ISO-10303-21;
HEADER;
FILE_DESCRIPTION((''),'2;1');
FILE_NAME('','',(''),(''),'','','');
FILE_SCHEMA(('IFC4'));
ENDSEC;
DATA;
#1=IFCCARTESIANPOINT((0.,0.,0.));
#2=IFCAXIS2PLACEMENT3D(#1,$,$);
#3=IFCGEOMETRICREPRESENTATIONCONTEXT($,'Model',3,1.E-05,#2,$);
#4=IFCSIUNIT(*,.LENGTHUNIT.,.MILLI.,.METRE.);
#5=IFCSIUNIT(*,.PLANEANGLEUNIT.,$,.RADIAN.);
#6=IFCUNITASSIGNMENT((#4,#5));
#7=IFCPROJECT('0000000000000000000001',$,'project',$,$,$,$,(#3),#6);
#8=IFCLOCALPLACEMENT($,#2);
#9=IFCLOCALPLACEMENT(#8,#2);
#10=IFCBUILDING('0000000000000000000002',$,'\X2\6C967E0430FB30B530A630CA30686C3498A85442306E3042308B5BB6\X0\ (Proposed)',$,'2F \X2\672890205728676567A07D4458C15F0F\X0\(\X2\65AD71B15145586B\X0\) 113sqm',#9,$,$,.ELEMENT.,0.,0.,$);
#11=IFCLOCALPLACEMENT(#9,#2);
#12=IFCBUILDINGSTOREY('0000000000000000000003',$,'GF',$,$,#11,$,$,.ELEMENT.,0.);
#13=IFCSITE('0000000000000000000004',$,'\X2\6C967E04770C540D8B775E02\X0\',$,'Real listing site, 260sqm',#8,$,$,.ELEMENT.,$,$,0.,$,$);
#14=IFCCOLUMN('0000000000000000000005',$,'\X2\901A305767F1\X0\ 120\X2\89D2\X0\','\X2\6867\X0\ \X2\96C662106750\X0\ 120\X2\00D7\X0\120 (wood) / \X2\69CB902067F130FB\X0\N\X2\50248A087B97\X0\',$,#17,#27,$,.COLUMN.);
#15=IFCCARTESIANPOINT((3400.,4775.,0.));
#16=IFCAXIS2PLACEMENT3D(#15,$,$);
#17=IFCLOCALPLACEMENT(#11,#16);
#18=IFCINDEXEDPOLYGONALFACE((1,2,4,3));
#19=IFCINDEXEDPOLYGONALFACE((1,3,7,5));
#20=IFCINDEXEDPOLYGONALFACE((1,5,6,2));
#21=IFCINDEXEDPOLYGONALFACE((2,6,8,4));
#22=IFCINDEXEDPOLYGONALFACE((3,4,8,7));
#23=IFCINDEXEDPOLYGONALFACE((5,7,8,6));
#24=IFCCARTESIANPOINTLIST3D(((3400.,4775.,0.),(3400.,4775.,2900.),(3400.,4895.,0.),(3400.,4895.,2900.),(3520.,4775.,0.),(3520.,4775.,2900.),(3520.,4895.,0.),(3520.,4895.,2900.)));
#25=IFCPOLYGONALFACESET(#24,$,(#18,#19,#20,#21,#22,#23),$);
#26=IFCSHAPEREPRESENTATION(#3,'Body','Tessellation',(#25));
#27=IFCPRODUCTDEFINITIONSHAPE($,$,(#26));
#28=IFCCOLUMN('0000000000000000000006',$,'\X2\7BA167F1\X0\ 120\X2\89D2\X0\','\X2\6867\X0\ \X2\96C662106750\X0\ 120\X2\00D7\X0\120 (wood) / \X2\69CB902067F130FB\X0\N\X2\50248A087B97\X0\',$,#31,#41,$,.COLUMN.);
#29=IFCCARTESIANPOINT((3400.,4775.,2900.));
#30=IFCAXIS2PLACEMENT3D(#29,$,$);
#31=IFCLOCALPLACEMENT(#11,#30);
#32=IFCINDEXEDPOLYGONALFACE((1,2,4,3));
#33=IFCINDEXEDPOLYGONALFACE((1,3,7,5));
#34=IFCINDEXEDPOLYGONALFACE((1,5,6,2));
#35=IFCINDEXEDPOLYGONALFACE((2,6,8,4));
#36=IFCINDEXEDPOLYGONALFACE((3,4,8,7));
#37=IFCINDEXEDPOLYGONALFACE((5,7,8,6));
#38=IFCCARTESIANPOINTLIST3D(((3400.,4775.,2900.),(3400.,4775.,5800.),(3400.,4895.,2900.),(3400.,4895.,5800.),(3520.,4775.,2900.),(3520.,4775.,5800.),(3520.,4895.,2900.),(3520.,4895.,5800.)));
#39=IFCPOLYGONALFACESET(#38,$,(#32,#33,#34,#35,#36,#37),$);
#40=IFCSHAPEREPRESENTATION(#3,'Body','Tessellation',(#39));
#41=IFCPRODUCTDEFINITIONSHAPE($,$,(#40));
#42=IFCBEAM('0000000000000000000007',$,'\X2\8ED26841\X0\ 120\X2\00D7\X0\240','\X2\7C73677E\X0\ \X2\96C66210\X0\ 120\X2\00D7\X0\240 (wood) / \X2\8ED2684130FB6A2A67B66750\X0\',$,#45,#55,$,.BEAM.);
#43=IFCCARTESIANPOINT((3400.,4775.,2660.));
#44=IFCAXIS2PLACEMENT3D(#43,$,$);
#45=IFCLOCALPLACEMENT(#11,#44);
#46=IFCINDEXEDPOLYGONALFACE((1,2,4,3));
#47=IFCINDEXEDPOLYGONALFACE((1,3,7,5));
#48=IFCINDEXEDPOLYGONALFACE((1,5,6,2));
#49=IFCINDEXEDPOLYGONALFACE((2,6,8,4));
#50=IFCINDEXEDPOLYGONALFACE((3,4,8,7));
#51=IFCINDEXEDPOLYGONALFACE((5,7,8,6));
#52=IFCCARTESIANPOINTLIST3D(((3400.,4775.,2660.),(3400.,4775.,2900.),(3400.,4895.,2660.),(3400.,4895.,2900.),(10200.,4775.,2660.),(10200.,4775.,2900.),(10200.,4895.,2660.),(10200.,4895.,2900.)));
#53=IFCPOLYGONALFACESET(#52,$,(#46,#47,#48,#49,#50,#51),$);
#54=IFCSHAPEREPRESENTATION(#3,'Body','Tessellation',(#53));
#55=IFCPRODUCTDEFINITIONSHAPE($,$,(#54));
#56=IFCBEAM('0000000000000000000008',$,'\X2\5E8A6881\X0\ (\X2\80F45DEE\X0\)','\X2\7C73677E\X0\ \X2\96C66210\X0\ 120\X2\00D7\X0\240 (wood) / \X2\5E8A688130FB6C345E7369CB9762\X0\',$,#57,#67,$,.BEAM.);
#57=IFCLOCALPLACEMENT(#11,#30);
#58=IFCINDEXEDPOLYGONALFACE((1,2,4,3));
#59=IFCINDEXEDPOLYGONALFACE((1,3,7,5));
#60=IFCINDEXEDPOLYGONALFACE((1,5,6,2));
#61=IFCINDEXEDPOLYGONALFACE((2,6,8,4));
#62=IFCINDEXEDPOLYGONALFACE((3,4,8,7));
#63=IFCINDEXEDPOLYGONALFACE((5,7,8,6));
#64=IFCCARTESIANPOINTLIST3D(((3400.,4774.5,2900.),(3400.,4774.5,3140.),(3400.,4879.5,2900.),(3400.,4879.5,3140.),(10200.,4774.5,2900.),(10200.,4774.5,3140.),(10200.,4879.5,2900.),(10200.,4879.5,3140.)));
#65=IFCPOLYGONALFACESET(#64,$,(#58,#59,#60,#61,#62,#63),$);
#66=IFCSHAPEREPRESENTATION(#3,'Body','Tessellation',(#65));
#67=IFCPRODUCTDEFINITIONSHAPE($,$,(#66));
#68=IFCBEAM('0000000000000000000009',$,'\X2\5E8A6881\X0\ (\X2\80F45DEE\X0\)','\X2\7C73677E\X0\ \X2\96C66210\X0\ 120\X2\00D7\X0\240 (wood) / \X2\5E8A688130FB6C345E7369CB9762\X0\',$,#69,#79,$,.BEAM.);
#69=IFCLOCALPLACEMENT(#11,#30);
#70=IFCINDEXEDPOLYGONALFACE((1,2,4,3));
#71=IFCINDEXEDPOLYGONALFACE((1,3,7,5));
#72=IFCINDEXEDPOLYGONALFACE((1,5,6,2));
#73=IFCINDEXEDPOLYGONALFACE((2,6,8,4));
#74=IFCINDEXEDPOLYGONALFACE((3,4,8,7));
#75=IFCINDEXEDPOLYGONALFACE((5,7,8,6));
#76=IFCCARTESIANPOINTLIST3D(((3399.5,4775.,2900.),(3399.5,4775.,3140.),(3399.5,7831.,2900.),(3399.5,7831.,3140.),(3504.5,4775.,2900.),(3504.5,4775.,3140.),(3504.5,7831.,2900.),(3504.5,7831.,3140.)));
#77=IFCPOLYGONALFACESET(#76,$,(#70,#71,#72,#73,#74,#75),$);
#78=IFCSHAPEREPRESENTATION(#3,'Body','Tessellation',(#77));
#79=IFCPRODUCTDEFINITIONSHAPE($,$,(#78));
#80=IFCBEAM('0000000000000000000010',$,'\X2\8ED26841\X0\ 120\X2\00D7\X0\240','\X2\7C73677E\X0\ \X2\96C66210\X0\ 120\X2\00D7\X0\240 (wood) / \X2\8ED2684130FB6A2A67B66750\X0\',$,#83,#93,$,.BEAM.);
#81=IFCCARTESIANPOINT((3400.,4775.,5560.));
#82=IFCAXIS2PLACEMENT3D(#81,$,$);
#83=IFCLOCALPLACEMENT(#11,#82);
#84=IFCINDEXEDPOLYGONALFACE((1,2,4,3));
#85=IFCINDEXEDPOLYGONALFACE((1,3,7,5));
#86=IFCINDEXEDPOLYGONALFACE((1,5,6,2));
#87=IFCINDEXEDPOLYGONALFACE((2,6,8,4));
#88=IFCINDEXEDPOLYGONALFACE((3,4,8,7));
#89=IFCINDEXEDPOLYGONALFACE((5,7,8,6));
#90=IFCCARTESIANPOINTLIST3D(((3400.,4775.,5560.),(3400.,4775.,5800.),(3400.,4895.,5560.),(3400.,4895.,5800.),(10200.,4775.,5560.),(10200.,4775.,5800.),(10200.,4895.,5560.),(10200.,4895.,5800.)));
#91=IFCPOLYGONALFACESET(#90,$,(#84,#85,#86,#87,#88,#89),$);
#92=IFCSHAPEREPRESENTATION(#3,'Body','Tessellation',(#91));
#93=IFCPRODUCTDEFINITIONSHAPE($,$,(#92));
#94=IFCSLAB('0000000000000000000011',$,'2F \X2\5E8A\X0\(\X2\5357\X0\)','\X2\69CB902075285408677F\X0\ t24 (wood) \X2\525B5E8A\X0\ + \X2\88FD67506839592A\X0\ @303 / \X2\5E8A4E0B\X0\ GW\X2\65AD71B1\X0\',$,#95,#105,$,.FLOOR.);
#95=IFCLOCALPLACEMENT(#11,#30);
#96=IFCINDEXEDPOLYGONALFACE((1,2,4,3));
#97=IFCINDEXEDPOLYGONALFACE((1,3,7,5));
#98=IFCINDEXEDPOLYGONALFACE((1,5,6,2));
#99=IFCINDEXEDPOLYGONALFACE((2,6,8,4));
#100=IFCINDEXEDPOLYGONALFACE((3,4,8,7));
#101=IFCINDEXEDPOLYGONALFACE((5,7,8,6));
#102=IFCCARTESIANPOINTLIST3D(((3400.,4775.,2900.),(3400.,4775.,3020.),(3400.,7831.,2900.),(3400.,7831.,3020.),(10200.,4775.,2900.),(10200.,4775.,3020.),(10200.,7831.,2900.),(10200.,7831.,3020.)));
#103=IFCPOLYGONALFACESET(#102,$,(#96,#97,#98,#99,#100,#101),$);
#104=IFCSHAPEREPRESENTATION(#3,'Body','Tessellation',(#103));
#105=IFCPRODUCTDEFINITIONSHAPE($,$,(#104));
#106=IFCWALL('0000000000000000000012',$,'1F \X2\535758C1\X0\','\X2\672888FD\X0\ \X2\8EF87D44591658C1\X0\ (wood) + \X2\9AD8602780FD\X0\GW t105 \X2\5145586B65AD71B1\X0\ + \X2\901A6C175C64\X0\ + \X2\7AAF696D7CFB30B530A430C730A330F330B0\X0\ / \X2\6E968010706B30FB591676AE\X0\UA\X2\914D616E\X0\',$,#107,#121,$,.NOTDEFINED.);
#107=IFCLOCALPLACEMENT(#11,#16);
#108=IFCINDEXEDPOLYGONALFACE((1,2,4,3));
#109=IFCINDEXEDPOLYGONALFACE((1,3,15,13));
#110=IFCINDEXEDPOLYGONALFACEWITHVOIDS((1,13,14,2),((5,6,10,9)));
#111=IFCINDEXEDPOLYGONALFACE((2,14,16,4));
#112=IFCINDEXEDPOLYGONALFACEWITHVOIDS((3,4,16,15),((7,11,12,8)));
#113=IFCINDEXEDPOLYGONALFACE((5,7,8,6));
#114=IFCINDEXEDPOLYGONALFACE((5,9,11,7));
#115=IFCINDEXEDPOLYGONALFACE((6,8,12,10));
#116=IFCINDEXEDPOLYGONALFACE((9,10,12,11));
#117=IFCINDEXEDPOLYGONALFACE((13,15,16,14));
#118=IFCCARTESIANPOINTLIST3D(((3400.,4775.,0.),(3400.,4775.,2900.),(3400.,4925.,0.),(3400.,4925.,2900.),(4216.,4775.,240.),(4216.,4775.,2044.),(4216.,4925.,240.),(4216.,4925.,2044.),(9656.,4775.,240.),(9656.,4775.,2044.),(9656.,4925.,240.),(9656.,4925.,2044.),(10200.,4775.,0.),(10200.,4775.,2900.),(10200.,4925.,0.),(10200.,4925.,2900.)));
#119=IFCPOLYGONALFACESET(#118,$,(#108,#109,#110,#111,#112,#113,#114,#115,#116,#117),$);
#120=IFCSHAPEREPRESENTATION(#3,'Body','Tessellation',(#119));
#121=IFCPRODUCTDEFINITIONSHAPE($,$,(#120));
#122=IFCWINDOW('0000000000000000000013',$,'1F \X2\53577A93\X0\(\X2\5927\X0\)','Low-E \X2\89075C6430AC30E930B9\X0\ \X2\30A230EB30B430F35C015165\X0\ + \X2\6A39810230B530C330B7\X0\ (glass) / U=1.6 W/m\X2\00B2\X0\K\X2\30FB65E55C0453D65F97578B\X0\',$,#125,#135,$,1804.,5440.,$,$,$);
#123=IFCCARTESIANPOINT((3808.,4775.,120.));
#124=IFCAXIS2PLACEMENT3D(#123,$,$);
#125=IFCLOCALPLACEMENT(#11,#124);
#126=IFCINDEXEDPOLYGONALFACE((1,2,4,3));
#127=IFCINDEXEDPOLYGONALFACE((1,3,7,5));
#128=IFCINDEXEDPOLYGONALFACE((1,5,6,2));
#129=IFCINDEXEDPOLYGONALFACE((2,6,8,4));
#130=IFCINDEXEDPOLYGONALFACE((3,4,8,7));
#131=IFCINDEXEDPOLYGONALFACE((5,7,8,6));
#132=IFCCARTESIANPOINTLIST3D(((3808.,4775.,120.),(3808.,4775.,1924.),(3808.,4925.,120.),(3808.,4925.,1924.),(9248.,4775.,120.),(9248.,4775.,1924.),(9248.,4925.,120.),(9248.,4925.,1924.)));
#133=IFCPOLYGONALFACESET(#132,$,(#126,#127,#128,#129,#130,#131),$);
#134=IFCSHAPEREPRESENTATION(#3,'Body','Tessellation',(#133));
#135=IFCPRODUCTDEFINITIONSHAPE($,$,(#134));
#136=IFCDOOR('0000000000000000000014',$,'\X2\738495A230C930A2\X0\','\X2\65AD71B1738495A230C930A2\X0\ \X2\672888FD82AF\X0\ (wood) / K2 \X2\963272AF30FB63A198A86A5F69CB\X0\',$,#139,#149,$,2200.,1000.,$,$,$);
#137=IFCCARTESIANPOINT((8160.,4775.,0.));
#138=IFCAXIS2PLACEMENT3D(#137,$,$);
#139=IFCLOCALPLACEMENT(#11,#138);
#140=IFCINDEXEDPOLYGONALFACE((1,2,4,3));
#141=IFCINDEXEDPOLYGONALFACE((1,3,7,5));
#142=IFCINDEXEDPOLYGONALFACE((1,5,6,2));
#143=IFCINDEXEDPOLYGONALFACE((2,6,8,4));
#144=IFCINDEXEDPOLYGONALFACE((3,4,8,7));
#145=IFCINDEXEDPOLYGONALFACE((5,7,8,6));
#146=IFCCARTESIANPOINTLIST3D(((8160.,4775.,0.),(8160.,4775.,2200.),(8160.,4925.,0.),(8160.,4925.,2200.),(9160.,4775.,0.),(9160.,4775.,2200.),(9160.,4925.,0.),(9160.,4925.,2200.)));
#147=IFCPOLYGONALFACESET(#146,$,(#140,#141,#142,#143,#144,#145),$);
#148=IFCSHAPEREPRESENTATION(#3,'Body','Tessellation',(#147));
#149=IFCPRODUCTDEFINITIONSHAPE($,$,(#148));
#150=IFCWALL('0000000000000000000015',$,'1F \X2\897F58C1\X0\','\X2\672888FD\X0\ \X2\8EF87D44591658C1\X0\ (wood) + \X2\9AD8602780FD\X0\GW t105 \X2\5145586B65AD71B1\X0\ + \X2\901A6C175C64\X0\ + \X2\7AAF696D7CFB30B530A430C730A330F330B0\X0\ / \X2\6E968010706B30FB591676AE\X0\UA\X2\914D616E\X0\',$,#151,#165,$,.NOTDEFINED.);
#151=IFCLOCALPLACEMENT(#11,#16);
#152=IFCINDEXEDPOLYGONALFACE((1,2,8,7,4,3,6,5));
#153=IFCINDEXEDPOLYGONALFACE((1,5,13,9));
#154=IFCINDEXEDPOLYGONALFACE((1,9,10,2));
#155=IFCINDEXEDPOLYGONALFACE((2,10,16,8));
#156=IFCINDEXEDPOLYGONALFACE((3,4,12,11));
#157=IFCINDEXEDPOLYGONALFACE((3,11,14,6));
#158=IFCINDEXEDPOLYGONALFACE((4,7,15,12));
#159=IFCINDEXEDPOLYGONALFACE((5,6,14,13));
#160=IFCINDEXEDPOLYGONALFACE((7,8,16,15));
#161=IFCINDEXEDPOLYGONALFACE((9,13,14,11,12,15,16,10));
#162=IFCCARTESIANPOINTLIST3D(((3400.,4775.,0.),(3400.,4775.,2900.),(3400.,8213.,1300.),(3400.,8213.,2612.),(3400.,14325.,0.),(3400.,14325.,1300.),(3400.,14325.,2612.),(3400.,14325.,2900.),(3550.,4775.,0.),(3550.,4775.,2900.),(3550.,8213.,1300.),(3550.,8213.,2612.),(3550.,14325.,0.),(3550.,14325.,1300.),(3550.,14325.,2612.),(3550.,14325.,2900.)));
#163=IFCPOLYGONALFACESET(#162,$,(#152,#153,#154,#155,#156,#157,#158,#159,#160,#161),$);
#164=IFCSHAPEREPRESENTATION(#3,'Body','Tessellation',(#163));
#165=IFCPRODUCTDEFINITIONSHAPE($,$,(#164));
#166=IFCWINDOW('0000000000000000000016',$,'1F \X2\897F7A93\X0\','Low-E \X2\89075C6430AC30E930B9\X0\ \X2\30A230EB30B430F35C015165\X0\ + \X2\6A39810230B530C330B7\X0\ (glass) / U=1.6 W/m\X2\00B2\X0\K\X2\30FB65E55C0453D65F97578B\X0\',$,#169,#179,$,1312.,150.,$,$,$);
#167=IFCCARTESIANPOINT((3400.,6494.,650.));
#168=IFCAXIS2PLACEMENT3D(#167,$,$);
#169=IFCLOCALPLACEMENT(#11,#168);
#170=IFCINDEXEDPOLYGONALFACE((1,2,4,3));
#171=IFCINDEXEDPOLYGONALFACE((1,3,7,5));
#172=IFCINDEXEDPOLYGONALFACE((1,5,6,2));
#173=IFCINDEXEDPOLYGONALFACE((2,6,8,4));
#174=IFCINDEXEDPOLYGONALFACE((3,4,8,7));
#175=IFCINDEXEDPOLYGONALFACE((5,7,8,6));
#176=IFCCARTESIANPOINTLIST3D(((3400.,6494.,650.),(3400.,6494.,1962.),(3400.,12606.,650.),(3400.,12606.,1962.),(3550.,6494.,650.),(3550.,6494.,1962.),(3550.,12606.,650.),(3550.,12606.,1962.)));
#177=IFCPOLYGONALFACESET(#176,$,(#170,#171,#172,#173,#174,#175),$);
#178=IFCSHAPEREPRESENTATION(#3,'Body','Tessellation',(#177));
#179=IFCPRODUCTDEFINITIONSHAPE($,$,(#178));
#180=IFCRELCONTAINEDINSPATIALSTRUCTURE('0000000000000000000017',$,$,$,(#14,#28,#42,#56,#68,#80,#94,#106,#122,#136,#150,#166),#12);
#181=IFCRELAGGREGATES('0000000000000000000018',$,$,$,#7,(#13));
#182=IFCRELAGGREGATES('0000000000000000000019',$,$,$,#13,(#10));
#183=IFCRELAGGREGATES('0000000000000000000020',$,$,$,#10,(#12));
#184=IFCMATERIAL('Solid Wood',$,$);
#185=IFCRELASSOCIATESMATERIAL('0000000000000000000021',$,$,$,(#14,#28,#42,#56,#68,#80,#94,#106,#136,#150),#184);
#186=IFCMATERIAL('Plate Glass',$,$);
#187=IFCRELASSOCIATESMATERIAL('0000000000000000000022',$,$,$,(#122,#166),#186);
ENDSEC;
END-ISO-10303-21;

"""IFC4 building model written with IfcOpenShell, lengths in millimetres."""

from ifc_helpers import new_model, si_unit, frame, frame_2d, origin, place, context, project, spatial, rectangle, extrude, material, element, fill, save


model = new_model("IFC4")

# Units and contexts
model_context = context("Model", 3, precision=1e-05, world=origin())
ifc_project = project(units=[si_unit("LENGTHUNIT", "METRE", prefix="MILLI"), si_unit("PLANEANGLEUNIT", "RADIAN")], contexts=[model_context])

# Site, building, storey
site_placement = place(None, origin())
site = spatial("IfcSite", under=ifc_project, at=site_placement, Name="沖縄県名護市", ObjectType="Real listing site, 260sqm", CompositionType="ELEMENT", RefElevation=0.0)
building_placement = place(site_placement, origin())
building = spatial("IfcBuilding", under=site, at=building_placement, Name="沖縄・サウナと水風呂のある家 (Proposed)", ObjectType="2F 木造在来枠組壁式(断熱充填) 113sqm", CompositionType="ELEMENT", ElevationOfRefHeight=0.0, ElevationOfTerrain=0.0)
storey_placement = place(building_placement, origin())
storey = spatial("IfcBuildingStorey", under=building, at=storey_placement, Name="GF", CompositionType="ELEMENT", Elevation=0.0)

# Columns
ifc_material_1 = material(Name="Solid Wood")
column_1_placement = place(storey_placement, frame((3400.0, 4775.0, 0.0)))
element("IfcColumn", 1, at=column_1_placement, inside=storey, material=ifc_material_1, Name="通し柱 120角", Description="桧 集成材 120×120 (wood) / 構造柱・N値計算", PredefinedType="COLUMN", context=model_context, shape_type="SweptSolid", body=[
    extrude(rectangle(XDim=120.0, YDim=120.0, at=frame_2d((60.0, 60.0))), frame((3400.0, 4775.0, 0.0)), (0.0, 0.0, 1.0), 2900.0),
])
column_2_placement = place(storey_placement, frame((3400.0, 4775.0, 2900.0)))
element("IfcColumn", 2, at=column_2_placement, inside=storey, material=ifc_material_1, Name="管柱 120角", Description="桧 集成材 120×120 (wood) / 構造柱・N値計算", PredefinedType="COLUMN", context=model_context, shape_type="SweptSolid", body=[
    extrude(rectangle(XDim=120.0, YDim=120.0, at=frame_2d((60.0, 60.0))), frame((3400.0, 4775.0, 2900.0)), (0.0, 0.0, 1.0), 2900.0),
])

# Beams
beam_1_placement = place(storey_placement, frame((3400.0, 4775.0, 2660.0)))
element("IfcBeam", 3, at=beam_1_placement, inside=storey, material=ifc_material_1, Name="軒桁 120×240", Description="米松 集成 120×240 (wood) / 軒桁・横架材", PredefinedType="BEAM", context=model_context, shape_type="SweptSolid", body=[
    extrude(rectangle(XDim=6800.0, YDim=120.0, at=frame_2d((3400.0, 60.0))), frame((3400.0, 4775.0, 2660.0)), (0.0, 0.0, 1.0), 240.0),
])
beam_2_placement = place(storey_placement, frame((3400.0, 4775.0, 2900.0)))
element("IfcBeam", 4, at=beam_2_placement, inside=storey, material=ifc_material_1, Name="床梁 (胴差)", Description="米松 集成 120×240 (wood) / 床梁・水平構面", PredefinedType="BEAM", context=model_context, shape_type="SweptSolid", body=[
    extrude(rectangle(XDim=6800.0, YDim=105.0, at=frame_2d((3400.0, 52.0))), frame((3400.0, 4775.0, 2900.0)), (0.0, 0.0, 1.0), 240.0),
])
beam_3_placement = place(storey_placement, frame((3400.0, 4775.0, 2900.0)))
element("IfcBeam", 5, at=beam_3_placement, inside=storey, material=ifc_material_1, Name="床梁 (胴差)", Description="米松 集成 120×240 (wood) / 床梁・水平構面", PredefinedType="BEAM", context=model_context, shape_type="SweptSolid", body=[
    extrude(rectangle(XDim=105.0, YDim=3056.0, at=frame_2d((52.0, 1528.0))), frame((3400.0, 4775.0, 2900.0)), (0.0, 0.0, 1.0), 240.0),
])
beam_4_placement = place(storey_placement, frame((3400.0, 4775.0, 5560.0)))
element("IfcBeam", 6, at=beam_4_placement, inside=storey, material=ifc_material_1, Name="軒桁 120×240", Description="米松 集成 120×240 (wood) / 軒桁・横架材", PredefinedType="BEAM", context=model_context, shape_type="SweptSolid", body=[
    extrude(rectangle(XDim=6800.0, YDim=120.0, at=frame_2d((3400.0, 60.0))), frame((3400.0, 4775.0, 5560.0)), (0.0, 0.0, 1.0), 240.0),
])

# Slab
slab_1_placement = place(storey_placement, frame((3400.0, 4775.0, 2900.0)))
element("IfcSlab", 7, at=slab_1_placement, inside=storey, material=ifc_material_1, Name="2F 床(南)", Description="構造用合板 t24 (wood) 剛床 + 製材根太 @303 / 床下 GW断熱", PredefinedType="FLOOR", context=model_context, shape_type="SweptSolid", body=[
    extrude(rectangle(XDim=6800.0, YDim=3056.0, at=frame_2d((3400.0, 1528.0))), frame((3400.0, 4775.0, 2900.0)), (0.0, 0.0, 1.0), 120.0),
])

# Wall, openings, window, door
wall_1_placement = place(storey_placement, frame((3400.0, 4775.0, 0.0)))
wall_1 = element("IfcWall", 8, at=wall_1_placement, inside=storey, material=ifc_material_1, Name="1F 南壁", Description="木製 軸組外壁 (wood) + 高性能GW t105 充填断熱 + 通気層 + 窯業系サイディング / 準耐火・外皮UA配慮", PredefinedType="NOTDEFINED", context=model_context, shape_type="SweptSolid", body=[
    extrude(rectangle(XDim=6800.0, YDim=150.0, at=frame_2d((3400.0, 75.0))), frame((3400.0, 4775.0, 0.0)), (0.0, 0.0, 1.0), 2900.0),
])
opening_1_placement = place(storey_placement, frame((3808.0, 4775.0, 120.0)))
opening_1 = element("IfcOpeningElement", 9, at=opening_1_placement, cuts=wall_1, PredefinedType="NOTDEFINED", context=model_context, shape_type="SweptSolid", body=[
    extrude(rectangle(XDim=5440.0, YDim=150.0, at=frame_2d((2720.0, 75.0))), frame((3808.0, 4775.0, 120.0)), (0.0, 0.0, 1.0), 1804.0),
])
opening_2_placement = place(storey_placement, frame((8160.0, 4775.0, 0.0)))
opening_2 = element("IfcOpeningElement", 10, at=opening_2_placement, cuts=wall_1, PredefinedType="NOTDEFINED", context=model_context, shape_type="SweptSolid", body=[
    extrude(rectangle(XDim=1000.0, YDim=150.0, at=frame_2d((500.0, 75.0))), frame((8160.0, 4775.0, 0.0)), (0.0, 0.0, 1.0), 2200.0),
])
ifc_material_2 = material(Name="Plate Glass")
window_1_placement = place(storey_placement, frame((3808.0, 4775.0, 120.0)))
window_1 = element("IfcWindow", 11, at=window_1_placement, inside=storey, material=ifc_material_2, Name="1F 南窓(大)", Description="Low-E 複層ガラス アルゴン封入 + 樹脂サッシ (glass) / U=1.6 W/m²K・日射取得型", OverallHeight=1804.0, OverallWidth=5440.0, context=model_context, shape_type="SweptSolid", body=[
    extrude(rectangle(XDim=5440.0, YDim=150.0, at=frame_2d((2720.0, 75.0))), frame((3808.0, 4775.0, 120.0)), (0.0, 0.0, 1.0), 1804.0),
])
fill(opening_1, window_1)
door_placement = place(storey_placement, frame((8160.0, 4775.0, 0.0)))
door = element("IfcDoor", 12, at=door_placement, inside=storey, material=ifc_material_1, Name="玄関ドア", Description="断熱玄関ドア 木製芯 (wood) / K2 防犯・採風機構", OverallHeight=2200.0, OverallWidth=1000.0, context=model_context, shape_type="SweptSolid", body=[
    extrude(rectangle(XDim=1000.0, YDim=150.0, at=frame_2d((500.0, 75.0))), frame((8160.0, 4775.0, 0.0)), (0.0, 0.0, 1.0), 2200.0),
])
fill(opening_2, door)

# Wall, opening, window
wall_2_placement = place(storey_placement, frame((3400.0, 4775.0, 0.0)))
wall_2 = element("IfcWall", 13, at=wall_2_placement, inside=storey, material=ifc_material_1, Name="1F 西壁", Description="木製 軸組外壁 (wood) + 高性能GW t105 充填断熱 + 通気層 + 窯業系サイディング / 準耐火・外皮UA配慮", PredefinedType="NOTDEFINED", context=model_context, shape_type="SweptSolid", body=[
    extrude(rectangle(XDim=150.0, YDim=9550.0, at=frame_2d((75.0, 4775.0))), frame((3400.0, 4775.0, 0.0)), (0.0, 0.0, 1.0), 2900.0),
])
opening_3_placement = place(storey_placement, frame((3400.0, 6494.0, 650.0)))
opening_3 = element("IfcOpeningElement", 14, at=opening_3_placement, cuts=wall_2, PredefinedType="NOTDEFINED", context=model_context, shape_type="SweptSolid", body=[
    extrude(rectangle(XDim=150.0, YDim=6112.0, at=frame_2d((75.0, 3056.0))), frame((3400.0, 6494.0, 650.0)), (0.0, 0.0, 1.0), 1312.0),
])
window_2_placement = place(storey_placement, frame((3400.0, 6494.0, 650.0)))
window_2 = element("IfcWindow", 15, at=window_2_placement, inside=storey, material=ifc_material_2, Name="1F 西窓", Description="Low-E 複層ガラス アルゴン封入 + 樹脂サッシ (glass) / U=1.6 W/m²K・日射取得型", OverallHeight=1312.0, OverallWidth=150.0, context=model_context, shape_type="SweptSolid", body=[
    extrude(rectangle(XDim=150.0, YDim=6112.0, at=frame_2d((75.0, 3056.0))), frame((3400.0, 6494.0, 650.0)), (0.0, 0.0, 1.0), 1312.0),
])
fill(opening_3, window_2)

save(model, "model.ifc")
